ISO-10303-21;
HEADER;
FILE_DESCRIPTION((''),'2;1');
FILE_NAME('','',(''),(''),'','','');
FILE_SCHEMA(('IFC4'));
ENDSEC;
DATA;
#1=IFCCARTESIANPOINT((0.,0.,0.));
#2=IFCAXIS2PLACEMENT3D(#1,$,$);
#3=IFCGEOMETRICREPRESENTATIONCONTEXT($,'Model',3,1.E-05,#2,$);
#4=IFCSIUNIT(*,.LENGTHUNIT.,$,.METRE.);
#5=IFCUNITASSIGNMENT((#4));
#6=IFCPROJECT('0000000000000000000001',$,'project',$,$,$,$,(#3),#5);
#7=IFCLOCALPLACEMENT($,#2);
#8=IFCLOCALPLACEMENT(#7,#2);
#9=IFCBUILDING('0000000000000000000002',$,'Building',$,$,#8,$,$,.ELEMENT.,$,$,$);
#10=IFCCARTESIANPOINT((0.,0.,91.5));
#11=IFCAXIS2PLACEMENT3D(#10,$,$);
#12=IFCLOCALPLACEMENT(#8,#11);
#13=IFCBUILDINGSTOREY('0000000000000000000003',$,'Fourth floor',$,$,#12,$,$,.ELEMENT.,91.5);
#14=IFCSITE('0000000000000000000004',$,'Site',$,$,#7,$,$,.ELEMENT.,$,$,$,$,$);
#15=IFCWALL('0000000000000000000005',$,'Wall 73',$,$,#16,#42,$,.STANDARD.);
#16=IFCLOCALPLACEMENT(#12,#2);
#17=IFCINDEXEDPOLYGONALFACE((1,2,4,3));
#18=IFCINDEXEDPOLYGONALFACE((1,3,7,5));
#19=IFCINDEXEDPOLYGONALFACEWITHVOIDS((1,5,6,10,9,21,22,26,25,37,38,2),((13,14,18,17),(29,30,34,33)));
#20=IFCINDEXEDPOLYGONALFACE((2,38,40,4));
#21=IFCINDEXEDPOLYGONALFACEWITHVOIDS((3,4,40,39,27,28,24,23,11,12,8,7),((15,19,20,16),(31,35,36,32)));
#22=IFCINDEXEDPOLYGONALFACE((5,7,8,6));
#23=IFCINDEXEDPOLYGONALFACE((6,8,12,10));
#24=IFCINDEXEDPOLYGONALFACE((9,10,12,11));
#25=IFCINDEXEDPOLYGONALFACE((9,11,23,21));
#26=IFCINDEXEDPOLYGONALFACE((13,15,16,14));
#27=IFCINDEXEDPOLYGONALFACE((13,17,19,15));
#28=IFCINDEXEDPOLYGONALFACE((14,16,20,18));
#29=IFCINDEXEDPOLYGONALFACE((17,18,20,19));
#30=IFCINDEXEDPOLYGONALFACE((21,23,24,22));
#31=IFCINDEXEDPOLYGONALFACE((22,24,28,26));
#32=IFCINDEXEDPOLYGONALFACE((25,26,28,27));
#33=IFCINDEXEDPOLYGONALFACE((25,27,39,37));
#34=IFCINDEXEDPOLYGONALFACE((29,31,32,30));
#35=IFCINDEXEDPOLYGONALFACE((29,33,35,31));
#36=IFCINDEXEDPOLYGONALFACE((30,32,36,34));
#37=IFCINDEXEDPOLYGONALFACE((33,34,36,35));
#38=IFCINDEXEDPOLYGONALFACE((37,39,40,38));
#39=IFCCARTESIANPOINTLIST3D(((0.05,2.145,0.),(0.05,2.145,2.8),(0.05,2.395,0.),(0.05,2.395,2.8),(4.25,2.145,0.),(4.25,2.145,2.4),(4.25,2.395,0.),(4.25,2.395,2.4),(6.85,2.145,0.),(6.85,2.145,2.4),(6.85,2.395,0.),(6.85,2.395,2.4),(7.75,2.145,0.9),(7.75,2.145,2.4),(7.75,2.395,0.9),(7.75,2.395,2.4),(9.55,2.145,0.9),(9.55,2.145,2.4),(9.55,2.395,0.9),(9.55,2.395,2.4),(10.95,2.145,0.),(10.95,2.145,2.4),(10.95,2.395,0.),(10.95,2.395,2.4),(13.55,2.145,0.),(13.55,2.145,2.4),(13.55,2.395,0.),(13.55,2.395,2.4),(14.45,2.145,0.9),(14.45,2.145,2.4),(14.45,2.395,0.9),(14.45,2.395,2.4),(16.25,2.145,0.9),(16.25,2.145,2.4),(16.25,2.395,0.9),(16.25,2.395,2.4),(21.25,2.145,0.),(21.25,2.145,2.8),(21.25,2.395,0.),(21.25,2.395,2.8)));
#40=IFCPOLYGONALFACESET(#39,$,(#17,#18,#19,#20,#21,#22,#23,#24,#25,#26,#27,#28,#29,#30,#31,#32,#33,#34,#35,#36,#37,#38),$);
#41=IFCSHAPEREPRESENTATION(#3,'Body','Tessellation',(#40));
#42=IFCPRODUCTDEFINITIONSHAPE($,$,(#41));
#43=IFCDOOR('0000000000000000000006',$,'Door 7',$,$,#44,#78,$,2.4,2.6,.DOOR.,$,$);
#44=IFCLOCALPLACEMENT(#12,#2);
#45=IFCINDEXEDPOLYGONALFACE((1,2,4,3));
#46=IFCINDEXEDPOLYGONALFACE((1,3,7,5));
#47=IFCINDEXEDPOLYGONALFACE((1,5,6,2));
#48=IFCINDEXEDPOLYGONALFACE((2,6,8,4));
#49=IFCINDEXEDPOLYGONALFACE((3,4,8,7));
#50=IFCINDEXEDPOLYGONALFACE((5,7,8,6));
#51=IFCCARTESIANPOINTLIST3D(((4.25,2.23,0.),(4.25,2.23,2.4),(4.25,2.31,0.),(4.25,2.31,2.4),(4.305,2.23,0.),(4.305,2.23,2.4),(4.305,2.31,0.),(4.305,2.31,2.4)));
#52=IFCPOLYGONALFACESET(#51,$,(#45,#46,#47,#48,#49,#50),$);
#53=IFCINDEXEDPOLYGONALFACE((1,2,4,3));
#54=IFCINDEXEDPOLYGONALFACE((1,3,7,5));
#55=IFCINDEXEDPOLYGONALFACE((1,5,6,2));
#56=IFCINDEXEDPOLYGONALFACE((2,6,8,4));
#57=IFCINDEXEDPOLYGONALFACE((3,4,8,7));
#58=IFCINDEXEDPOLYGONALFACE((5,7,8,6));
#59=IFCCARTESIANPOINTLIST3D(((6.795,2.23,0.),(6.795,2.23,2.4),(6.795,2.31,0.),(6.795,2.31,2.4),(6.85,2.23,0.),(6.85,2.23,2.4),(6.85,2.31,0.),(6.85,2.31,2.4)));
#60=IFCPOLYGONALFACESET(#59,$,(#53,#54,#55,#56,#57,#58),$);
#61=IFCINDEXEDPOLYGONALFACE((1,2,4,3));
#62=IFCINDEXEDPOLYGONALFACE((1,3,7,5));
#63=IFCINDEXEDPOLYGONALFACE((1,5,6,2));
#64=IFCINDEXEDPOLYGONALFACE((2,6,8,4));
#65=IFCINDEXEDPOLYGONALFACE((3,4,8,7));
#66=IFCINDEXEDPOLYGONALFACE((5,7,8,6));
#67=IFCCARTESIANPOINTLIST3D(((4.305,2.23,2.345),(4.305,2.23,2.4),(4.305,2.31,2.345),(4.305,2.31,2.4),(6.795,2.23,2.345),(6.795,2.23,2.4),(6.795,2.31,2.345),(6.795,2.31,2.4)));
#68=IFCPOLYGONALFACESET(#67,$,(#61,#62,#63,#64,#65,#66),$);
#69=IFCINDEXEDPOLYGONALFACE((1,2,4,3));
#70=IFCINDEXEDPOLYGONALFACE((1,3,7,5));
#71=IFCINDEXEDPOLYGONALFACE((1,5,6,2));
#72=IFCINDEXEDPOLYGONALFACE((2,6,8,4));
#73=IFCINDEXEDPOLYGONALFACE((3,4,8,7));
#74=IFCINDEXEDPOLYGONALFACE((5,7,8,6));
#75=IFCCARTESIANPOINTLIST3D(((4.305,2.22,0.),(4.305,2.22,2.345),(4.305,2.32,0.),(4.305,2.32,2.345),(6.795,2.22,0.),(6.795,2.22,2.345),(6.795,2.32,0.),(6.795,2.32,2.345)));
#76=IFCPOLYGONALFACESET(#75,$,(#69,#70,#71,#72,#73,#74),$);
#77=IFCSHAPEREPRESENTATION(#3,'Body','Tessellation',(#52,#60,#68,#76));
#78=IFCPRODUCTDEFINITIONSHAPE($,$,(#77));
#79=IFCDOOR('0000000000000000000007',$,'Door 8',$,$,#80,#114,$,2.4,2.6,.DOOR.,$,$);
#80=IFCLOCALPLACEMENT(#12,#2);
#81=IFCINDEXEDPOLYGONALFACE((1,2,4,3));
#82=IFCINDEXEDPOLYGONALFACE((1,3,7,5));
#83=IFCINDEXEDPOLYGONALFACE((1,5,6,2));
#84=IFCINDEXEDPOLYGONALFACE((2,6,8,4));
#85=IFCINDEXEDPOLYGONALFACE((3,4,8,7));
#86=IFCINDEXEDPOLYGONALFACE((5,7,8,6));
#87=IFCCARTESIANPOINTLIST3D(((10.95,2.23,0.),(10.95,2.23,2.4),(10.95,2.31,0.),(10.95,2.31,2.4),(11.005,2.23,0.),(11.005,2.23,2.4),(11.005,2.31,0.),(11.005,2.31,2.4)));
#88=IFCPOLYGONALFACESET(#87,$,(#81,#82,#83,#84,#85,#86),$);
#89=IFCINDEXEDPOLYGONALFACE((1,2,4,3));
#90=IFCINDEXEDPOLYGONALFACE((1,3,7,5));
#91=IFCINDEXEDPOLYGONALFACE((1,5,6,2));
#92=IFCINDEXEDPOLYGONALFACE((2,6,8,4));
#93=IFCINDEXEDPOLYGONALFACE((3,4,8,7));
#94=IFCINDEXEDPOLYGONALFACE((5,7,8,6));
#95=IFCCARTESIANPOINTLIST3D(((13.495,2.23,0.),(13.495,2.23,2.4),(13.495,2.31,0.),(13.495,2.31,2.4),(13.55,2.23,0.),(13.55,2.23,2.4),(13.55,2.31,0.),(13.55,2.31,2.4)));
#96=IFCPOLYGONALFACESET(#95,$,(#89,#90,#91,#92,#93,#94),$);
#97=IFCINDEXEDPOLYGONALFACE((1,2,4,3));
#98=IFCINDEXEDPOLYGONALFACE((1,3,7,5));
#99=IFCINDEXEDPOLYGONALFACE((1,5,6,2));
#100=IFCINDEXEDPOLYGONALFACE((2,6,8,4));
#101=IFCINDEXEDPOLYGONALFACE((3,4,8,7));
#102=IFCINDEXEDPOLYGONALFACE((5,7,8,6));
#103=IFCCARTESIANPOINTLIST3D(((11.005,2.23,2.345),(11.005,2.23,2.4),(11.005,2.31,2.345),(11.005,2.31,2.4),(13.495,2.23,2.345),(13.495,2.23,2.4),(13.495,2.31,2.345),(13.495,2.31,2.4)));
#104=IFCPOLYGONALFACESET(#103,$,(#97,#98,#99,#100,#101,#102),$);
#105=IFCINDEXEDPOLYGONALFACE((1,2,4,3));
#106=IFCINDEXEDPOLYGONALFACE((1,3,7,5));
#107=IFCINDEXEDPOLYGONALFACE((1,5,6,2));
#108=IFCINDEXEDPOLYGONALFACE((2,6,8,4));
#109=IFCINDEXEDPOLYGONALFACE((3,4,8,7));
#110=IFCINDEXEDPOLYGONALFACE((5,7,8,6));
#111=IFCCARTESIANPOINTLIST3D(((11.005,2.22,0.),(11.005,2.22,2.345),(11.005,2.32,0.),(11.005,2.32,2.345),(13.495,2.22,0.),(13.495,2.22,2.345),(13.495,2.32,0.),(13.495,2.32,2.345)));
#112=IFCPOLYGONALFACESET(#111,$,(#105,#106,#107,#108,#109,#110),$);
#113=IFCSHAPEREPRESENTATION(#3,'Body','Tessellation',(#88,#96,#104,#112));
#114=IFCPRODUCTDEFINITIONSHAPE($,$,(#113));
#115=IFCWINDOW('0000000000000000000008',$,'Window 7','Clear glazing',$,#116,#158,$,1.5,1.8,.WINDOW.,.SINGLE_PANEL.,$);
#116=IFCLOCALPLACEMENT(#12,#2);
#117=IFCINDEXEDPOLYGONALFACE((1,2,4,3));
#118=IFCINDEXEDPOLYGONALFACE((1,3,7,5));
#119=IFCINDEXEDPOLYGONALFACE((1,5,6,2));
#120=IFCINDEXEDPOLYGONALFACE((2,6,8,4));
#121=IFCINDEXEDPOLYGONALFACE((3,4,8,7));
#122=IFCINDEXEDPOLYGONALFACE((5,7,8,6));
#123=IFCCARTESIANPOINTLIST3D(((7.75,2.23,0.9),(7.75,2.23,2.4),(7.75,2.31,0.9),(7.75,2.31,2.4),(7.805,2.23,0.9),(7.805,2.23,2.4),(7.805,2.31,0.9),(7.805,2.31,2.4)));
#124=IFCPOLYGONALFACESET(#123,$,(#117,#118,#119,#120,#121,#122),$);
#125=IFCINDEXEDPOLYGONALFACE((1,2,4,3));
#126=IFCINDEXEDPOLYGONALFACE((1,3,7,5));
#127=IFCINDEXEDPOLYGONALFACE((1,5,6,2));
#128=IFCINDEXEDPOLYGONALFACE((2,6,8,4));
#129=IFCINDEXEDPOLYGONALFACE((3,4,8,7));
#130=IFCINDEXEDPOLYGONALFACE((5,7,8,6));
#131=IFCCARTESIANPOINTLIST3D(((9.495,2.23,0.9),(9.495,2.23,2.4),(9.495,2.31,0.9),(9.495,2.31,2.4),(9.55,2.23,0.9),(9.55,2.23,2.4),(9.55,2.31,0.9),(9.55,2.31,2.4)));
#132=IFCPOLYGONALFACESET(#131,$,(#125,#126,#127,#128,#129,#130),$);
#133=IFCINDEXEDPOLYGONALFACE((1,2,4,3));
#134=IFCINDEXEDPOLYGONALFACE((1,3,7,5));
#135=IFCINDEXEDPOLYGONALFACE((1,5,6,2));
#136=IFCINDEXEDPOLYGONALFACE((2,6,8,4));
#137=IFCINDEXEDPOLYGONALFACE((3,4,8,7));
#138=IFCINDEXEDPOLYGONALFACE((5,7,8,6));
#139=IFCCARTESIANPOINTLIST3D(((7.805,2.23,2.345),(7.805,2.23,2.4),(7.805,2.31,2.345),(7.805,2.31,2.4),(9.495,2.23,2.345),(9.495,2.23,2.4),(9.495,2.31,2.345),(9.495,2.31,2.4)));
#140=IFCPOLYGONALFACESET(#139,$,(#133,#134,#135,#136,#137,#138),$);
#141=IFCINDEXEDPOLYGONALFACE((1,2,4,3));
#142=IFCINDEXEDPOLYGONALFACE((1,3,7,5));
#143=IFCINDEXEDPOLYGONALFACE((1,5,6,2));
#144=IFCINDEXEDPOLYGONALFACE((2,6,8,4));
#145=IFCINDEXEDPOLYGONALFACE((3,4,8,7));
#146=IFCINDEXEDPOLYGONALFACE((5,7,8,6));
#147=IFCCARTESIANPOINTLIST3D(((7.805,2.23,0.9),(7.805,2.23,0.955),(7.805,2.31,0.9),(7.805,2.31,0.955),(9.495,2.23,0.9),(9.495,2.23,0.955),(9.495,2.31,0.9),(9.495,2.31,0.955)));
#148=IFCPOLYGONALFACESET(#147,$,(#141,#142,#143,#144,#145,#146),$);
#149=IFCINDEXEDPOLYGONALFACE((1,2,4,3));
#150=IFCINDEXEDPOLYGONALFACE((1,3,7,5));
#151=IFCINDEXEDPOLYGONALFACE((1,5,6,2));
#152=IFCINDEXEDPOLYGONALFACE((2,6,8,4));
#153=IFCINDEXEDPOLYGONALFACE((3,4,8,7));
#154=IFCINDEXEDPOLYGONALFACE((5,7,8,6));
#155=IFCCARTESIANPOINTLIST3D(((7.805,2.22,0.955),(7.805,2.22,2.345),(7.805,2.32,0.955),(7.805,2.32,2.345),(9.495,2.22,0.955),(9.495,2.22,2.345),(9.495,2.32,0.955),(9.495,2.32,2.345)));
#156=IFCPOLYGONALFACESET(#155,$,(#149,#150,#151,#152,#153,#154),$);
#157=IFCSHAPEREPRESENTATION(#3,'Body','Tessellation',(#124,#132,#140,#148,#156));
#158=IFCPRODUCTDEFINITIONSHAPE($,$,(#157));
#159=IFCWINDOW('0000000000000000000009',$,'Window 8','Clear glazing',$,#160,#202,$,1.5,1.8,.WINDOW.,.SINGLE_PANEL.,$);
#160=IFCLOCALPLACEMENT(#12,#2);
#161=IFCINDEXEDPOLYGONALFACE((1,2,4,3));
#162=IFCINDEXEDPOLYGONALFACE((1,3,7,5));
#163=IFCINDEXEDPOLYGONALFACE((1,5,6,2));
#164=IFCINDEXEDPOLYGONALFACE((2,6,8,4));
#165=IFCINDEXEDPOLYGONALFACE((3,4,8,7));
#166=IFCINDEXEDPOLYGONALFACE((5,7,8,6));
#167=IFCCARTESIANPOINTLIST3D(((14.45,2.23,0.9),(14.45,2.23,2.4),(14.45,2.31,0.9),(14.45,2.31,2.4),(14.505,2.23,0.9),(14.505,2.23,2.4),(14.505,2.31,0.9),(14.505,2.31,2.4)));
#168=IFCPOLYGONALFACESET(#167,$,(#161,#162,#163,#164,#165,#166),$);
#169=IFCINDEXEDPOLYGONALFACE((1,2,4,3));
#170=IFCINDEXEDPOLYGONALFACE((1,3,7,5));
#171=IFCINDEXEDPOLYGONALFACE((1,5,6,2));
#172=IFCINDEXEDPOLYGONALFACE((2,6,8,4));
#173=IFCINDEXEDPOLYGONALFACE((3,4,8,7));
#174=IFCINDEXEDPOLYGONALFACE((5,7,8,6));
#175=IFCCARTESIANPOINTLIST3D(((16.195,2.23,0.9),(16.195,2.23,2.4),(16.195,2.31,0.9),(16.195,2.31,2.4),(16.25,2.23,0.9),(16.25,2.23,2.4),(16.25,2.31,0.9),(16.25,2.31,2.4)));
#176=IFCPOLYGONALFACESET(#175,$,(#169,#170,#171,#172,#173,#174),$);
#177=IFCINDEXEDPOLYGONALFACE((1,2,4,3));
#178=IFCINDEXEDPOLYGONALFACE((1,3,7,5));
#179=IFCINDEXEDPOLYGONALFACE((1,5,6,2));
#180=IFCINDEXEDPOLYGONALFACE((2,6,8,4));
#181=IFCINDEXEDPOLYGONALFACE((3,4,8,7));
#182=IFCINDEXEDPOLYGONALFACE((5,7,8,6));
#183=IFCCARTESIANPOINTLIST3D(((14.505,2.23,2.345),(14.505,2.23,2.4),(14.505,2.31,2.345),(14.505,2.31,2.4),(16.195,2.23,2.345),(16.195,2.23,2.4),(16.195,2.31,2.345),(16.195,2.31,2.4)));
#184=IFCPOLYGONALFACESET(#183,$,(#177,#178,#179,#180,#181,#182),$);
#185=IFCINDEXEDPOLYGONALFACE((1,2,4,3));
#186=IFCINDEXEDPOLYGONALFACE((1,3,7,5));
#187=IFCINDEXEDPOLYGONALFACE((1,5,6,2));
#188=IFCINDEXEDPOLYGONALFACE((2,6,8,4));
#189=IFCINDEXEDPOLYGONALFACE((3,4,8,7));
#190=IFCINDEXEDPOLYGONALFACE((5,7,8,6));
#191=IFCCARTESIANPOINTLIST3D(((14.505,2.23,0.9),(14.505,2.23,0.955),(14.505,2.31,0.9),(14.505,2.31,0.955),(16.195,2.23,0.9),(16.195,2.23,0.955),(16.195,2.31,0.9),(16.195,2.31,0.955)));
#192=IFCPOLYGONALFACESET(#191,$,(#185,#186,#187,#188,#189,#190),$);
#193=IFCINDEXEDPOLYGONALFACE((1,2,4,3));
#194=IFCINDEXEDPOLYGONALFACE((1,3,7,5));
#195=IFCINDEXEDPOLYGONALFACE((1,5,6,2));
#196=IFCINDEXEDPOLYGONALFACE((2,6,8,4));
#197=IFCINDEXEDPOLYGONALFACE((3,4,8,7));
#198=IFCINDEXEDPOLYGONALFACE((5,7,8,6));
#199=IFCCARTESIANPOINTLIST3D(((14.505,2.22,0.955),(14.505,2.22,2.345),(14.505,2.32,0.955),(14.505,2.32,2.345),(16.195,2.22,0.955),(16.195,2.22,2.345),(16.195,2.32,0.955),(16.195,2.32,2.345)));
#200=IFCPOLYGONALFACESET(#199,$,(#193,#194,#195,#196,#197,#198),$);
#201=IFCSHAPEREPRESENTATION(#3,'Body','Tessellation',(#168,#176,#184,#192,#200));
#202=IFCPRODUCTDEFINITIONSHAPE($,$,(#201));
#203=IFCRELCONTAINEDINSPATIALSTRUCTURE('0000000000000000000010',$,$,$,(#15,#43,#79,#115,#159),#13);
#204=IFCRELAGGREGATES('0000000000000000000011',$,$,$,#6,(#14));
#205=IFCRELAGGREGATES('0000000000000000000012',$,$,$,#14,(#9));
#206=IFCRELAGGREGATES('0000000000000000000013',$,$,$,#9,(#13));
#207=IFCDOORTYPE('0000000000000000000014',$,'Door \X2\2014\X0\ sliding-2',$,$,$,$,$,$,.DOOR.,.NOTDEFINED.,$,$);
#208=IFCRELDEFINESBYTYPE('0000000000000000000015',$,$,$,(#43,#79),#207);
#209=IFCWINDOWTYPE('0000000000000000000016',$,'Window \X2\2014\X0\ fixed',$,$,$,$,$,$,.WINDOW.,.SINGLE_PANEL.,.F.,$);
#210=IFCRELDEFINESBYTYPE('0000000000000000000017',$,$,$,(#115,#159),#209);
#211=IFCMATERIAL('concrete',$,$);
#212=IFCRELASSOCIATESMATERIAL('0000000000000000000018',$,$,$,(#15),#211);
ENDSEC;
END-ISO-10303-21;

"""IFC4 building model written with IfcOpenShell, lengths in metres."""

from ifc_helpers import new_model, si_unit, frame, frame_2d, origin, place, context, project, spatial, rectangle, extrude, material, type_object, element, fill, save


model = new_model("IFC4")

# Units and contexts
model_context = context("Model", 3, precision=1e-05, world=origin())
ifc_project = project(units=[si_unit("LENGTHUNIT", "METRE")], contexts=[model_context])

# Site, building, storey
site_placement = place(None, origin())
site = spatial("IfcSite", under=ifc_project, at=site_placement, Name="Site", CompositionType="ELEMENT")
building_placement = place(site_placement, origin())
building = spatial("IfcBuilding", under=site, at=building_placement, Name="Building", CompositionType="ELEMENT")
storey_placement = place(building_placement, frame((0.0, 0.0, 91.5)))
storey = spatial("IfcBuildingStorey", under=building, at=storey_placement, Name="Fourth floor", CompositionType="ELEMENT", Elevation=91.5)

# Shared definitions
ifc_material = material(Name="concrete")

# Wall, openings, doors, windows
wall_1_placement = place(storey_placement, frame((0.05, 2.27, 0.0), z_axis=(0.0, 0.0, 1.0), x_axis=(1.0, 0.0, 0.0)))
wall_1 = element("IfcWall", 1, at=wall_1_placement, inside=storey, material=ifc_material, Name="Wall 73", PredefinedType="STANDARD", context=model_context, shape_type="SweptSolid", body=[
    extrude(rectangle(XDim=21.2, YDim=0.25, at=frame_2d((10.6, 0.0))), origin(), (0.0, 0.0, 1.0), 2.8),
])
opening_1_placement = place(storey_placement, frame((4.25, 2.27, 0.0), z_axis=(0.0, 0.0, 1.0), x_axis=(1.0, 0.0, 0.0)))
opening_1 = element("IfcOpeningElement", 2, at=opening_1_placement, cuts=wall_1, PredefinedType="OPENING", context=model_context, shape_type="SweptSolid", body=[
    extrude(rectangle(XDim=2.6, YDim=0.31, at=frame_2d((1.3, 0.0))), origin(), (0.0, 0.0, 1.0), 2.4),
])
opening_2_placement = place(storey_placement, frame((7.75, 2.27, 0.9), z_axis=(0.0, 0.0, 1.0), x_axis=(1.0, 0.0, 0.0)))
opening_2 = element("IfcOpeningElement", 3, at=opening_2_placement, cuts=wall_1, PredefinedType="OPENING", context=model_context, shape_type="SweptSolid", body=[
    extrude(rectangle(XDim=1.8, YDim=0.31, at=frame_2d((0.9, 0.0))), origin(), (0.0, 0.0, 1.0), 1.5),
])
opening_3_placement = place(storey_placement, frame((10.95, 2.27, 0.0), z_axis=(0.0, 0.0, 1.0), x_axis=(1.0, 0.0, 0.0)))
opening_3 = element("IfcOpeningElement", 4, at=opening_3_placement, cuts=wall_1, PredefinedType="OPENING", context=model_context, shape_type="SweptSolid", body=[
    extrude(rectangle(XDim=2.6, YDim=0.31, at=frame_2d((1.3, 0.0))), origin(), (0.0, 0.0, 1.0), 2.4),
])
opening_4_placement = place(storey_placement, frame((14.45, 2.27, 0.9), z_axis=(0.0, 0.0, 1.0), x_axis=(1.0, 0.0, 0.0)))
opening_4 = element("IfcOpeningElement", 5, at=opening_4_placement, cuts=wall_1, PredefinedType="OPENING", context=model_context, shape_type="SweptSolid", body=[
    extrude(rectangle(XDim=1.8, YDim=0.31, at=frame_2d((0.9, 0.0))), origin(), (0.0, 0.0, 1.0), 1.5),
])
door_type = type_object("IfcDoorType", Name="Door — sliding-2", PredefinedType="DOOR")
door_1_placement = place(storey_placement, frame((4.25, 2.27, 0.0), z_axis=(0.0, 0.0, 1.0), x_axis=(1.0, 0.0, 0.0)))
door_1 = element("IfcDoor", 6, at=door_1_placement, inside=storey, type_object=door_type, Name="Door 7", OverallHeight=2.4, OverallWidth=2.6, PredefinedType="DOOR", context=model_context, shape_type="SweptSolid", body=[
    extrude(rectangle(XDim=0.055, YDim=0.08, at=frame_2d((0.0275, 0.0))), origin(), (0.0, 0.0, 1.0), 2.4),
    extrude(rectangle(XDim=0.055, YDim=0.08, at=frame_2d((2.5725, 0.0))), origin(), (0.0, 0.0, 1.0), 2.4),
    extrude(rectangle(XDim=2.49, YDim=0.08, at=frame_2d((1.3, 0.0))), frame((0.0, 0.0, 2.345)), (0.0, 0.0, 1.0), 0.055),
    extrude(rectangle(XDim=2.49, YDim=0.1, at=frame_2d((1.3, 0.0))), origin(), (0.0, 0.0, 1.0), 2.345),
])
fill(opening_1, door_1)
door_2_placement = place(storey_placement, frame((10.95, 2.27, 0.0), z_axis=(0.0, 0.0, 1.0), x_axis=(1.0, 0.0, 0.0)))
door_2 = element("IfcDoor", 7, at=door_2_placement, inside=storey, type_object=door_type, Name="Door 8", OverallHeight=2.4, OverallWidth=2.6, PredefinedType="DOOR", context=model_context, shape_type="SweptSolid", body=[
    extrude(rectangle(XDim=0.055, YDim=0.08, at=frame_2d((0.0275, 0.0))), origin(), (0.0, 0.0, 1.0), 2.4),
    extrude(rectangle(XDim=0.055, YDim=0.08, at=frame_2d((2.5725, 0.0))), origin(), (0.0, 0.0, 1.0), 2.4),
    extrude(rectangle(XDim=2.49, YDim=0.08, at=frame_2d((1.3, 0.0))), frame((0.0, 0.0, 2.345)), (0.0, 0.0, 1.0), 0.055),
    extrude(rectangle(XDim=2.49, YDim=0.1, at=frame_2d((1.3, 0.0))), origin(), (0.0, 0.0, 1.0), 2.345),
])
fill(opening_3, door_2)
window_type = type_object("IfcWindowType", Name="Window — fixed", ParameterTakesPrecedence=False, PartitioningType="SINGLE_PANEL", PredefinedType="WINDOW")
window_1_placement = place(storey_placement, frame((7.75, 2.27, 0.9), z_axis=(0.0, 0.0, 1.0), x_axis=(1.0, 0.0, 0.0)))
window_1 = element("IfcWindow", 8, at=window_1_placement, inside=storey, type_object=window_type, Name="Window 7", Description="Clear glazing", OverallHeight=1.5, OverallWidth=1.8, PartitioningType="SINGLE_PANEL", PredefinedType="WINDOW", context=model_context, shape_type="SweptSolid", body=[
    extrude(rectangle(XDim=0.055, YDim=0.08, at=frame_2d((0.0275, 0.0))), origin(), (0.0, 0.0, 1.0), 1.5),
    extrude(rectangle(XDim=0.055, YDim=0.08, at=frame_2d((1.7725, 0.0))), origin(), (0.0, 0.0, 1.0), 1.5),
    extrude(rectangle(XDim=1.69, YDim=0.08, at=frame_2d((0.9, 0.0))), frame((0.0, 0.0, 1.445)), (0.0, 0.0, 1.0), 0.055),
    extrude(rectangle(XDim=1.69, YDim=0.08, at=frame_2d((0.9, 0.0))), origin(), (0.0, 0.0, 1.0), 0.055),
    extrude(rectangle(XDim=1.69, YDim=0.1, at=frame_2d((0.9, 0.0))), frame((0.0, 0.0, 0.055)), (0.0, 0.0, 1.0), 1.39),
])
fill(opening_2, window_1)
window_2_placement = place(storey_placement, frame((14.45, 2.27, 0.9), z_axis=(0.0, 0.0, 1.0), x_axis=(1.0, 0.0, 0.0)))
window_2 = element("IfcWindow", 9, at=window_2_placement, inside=storey, type_object=window_type, Name="Window 8", Description="Clear glazing", OverallHeight=1.5, OverallWidth=1.8, PartitioningType="SINGLE_PANEL", PredefinedType="WINDOW", context=model_context, shape_type="SweptSolid", body=[
    extrude(rectangle(XDim=0.055, YDim=0.08, at=frame_2d((0.0275, 0.0))), origin(), (0.0, 0.0, 1.0), 1.5),
    extrude(rectangle(XDim=0.055, YDim=0.08, at=frame_2d((1.7725, 0.0))), origin(), (0.0, 0.0, 1.0), 1.5),
    extrude(rectangle(XDim=1.69, YDim=0.08, at=frame_2d((0.9, 0.0))), frame((0.0, 0.0, 1.445)), (0.0, 0.0, 1.0), 0.055),
    extrude(rectangle(XDim=1.69, YDim=0.08, at=frame_2d((0.9, 0.0))), origin(), (0.0, 0.0, 1.0), 0.055),
    extrude(rectangle(XDim=1.69, YDim=0.1, at=frame_2d((0.9, 0.0))), frame((0.0, 0.0, 0.055)), (0.0, 0.0, 1.0), 1.39),
])
fill(opening_4, window_2)

save(model, "model.ifc")
